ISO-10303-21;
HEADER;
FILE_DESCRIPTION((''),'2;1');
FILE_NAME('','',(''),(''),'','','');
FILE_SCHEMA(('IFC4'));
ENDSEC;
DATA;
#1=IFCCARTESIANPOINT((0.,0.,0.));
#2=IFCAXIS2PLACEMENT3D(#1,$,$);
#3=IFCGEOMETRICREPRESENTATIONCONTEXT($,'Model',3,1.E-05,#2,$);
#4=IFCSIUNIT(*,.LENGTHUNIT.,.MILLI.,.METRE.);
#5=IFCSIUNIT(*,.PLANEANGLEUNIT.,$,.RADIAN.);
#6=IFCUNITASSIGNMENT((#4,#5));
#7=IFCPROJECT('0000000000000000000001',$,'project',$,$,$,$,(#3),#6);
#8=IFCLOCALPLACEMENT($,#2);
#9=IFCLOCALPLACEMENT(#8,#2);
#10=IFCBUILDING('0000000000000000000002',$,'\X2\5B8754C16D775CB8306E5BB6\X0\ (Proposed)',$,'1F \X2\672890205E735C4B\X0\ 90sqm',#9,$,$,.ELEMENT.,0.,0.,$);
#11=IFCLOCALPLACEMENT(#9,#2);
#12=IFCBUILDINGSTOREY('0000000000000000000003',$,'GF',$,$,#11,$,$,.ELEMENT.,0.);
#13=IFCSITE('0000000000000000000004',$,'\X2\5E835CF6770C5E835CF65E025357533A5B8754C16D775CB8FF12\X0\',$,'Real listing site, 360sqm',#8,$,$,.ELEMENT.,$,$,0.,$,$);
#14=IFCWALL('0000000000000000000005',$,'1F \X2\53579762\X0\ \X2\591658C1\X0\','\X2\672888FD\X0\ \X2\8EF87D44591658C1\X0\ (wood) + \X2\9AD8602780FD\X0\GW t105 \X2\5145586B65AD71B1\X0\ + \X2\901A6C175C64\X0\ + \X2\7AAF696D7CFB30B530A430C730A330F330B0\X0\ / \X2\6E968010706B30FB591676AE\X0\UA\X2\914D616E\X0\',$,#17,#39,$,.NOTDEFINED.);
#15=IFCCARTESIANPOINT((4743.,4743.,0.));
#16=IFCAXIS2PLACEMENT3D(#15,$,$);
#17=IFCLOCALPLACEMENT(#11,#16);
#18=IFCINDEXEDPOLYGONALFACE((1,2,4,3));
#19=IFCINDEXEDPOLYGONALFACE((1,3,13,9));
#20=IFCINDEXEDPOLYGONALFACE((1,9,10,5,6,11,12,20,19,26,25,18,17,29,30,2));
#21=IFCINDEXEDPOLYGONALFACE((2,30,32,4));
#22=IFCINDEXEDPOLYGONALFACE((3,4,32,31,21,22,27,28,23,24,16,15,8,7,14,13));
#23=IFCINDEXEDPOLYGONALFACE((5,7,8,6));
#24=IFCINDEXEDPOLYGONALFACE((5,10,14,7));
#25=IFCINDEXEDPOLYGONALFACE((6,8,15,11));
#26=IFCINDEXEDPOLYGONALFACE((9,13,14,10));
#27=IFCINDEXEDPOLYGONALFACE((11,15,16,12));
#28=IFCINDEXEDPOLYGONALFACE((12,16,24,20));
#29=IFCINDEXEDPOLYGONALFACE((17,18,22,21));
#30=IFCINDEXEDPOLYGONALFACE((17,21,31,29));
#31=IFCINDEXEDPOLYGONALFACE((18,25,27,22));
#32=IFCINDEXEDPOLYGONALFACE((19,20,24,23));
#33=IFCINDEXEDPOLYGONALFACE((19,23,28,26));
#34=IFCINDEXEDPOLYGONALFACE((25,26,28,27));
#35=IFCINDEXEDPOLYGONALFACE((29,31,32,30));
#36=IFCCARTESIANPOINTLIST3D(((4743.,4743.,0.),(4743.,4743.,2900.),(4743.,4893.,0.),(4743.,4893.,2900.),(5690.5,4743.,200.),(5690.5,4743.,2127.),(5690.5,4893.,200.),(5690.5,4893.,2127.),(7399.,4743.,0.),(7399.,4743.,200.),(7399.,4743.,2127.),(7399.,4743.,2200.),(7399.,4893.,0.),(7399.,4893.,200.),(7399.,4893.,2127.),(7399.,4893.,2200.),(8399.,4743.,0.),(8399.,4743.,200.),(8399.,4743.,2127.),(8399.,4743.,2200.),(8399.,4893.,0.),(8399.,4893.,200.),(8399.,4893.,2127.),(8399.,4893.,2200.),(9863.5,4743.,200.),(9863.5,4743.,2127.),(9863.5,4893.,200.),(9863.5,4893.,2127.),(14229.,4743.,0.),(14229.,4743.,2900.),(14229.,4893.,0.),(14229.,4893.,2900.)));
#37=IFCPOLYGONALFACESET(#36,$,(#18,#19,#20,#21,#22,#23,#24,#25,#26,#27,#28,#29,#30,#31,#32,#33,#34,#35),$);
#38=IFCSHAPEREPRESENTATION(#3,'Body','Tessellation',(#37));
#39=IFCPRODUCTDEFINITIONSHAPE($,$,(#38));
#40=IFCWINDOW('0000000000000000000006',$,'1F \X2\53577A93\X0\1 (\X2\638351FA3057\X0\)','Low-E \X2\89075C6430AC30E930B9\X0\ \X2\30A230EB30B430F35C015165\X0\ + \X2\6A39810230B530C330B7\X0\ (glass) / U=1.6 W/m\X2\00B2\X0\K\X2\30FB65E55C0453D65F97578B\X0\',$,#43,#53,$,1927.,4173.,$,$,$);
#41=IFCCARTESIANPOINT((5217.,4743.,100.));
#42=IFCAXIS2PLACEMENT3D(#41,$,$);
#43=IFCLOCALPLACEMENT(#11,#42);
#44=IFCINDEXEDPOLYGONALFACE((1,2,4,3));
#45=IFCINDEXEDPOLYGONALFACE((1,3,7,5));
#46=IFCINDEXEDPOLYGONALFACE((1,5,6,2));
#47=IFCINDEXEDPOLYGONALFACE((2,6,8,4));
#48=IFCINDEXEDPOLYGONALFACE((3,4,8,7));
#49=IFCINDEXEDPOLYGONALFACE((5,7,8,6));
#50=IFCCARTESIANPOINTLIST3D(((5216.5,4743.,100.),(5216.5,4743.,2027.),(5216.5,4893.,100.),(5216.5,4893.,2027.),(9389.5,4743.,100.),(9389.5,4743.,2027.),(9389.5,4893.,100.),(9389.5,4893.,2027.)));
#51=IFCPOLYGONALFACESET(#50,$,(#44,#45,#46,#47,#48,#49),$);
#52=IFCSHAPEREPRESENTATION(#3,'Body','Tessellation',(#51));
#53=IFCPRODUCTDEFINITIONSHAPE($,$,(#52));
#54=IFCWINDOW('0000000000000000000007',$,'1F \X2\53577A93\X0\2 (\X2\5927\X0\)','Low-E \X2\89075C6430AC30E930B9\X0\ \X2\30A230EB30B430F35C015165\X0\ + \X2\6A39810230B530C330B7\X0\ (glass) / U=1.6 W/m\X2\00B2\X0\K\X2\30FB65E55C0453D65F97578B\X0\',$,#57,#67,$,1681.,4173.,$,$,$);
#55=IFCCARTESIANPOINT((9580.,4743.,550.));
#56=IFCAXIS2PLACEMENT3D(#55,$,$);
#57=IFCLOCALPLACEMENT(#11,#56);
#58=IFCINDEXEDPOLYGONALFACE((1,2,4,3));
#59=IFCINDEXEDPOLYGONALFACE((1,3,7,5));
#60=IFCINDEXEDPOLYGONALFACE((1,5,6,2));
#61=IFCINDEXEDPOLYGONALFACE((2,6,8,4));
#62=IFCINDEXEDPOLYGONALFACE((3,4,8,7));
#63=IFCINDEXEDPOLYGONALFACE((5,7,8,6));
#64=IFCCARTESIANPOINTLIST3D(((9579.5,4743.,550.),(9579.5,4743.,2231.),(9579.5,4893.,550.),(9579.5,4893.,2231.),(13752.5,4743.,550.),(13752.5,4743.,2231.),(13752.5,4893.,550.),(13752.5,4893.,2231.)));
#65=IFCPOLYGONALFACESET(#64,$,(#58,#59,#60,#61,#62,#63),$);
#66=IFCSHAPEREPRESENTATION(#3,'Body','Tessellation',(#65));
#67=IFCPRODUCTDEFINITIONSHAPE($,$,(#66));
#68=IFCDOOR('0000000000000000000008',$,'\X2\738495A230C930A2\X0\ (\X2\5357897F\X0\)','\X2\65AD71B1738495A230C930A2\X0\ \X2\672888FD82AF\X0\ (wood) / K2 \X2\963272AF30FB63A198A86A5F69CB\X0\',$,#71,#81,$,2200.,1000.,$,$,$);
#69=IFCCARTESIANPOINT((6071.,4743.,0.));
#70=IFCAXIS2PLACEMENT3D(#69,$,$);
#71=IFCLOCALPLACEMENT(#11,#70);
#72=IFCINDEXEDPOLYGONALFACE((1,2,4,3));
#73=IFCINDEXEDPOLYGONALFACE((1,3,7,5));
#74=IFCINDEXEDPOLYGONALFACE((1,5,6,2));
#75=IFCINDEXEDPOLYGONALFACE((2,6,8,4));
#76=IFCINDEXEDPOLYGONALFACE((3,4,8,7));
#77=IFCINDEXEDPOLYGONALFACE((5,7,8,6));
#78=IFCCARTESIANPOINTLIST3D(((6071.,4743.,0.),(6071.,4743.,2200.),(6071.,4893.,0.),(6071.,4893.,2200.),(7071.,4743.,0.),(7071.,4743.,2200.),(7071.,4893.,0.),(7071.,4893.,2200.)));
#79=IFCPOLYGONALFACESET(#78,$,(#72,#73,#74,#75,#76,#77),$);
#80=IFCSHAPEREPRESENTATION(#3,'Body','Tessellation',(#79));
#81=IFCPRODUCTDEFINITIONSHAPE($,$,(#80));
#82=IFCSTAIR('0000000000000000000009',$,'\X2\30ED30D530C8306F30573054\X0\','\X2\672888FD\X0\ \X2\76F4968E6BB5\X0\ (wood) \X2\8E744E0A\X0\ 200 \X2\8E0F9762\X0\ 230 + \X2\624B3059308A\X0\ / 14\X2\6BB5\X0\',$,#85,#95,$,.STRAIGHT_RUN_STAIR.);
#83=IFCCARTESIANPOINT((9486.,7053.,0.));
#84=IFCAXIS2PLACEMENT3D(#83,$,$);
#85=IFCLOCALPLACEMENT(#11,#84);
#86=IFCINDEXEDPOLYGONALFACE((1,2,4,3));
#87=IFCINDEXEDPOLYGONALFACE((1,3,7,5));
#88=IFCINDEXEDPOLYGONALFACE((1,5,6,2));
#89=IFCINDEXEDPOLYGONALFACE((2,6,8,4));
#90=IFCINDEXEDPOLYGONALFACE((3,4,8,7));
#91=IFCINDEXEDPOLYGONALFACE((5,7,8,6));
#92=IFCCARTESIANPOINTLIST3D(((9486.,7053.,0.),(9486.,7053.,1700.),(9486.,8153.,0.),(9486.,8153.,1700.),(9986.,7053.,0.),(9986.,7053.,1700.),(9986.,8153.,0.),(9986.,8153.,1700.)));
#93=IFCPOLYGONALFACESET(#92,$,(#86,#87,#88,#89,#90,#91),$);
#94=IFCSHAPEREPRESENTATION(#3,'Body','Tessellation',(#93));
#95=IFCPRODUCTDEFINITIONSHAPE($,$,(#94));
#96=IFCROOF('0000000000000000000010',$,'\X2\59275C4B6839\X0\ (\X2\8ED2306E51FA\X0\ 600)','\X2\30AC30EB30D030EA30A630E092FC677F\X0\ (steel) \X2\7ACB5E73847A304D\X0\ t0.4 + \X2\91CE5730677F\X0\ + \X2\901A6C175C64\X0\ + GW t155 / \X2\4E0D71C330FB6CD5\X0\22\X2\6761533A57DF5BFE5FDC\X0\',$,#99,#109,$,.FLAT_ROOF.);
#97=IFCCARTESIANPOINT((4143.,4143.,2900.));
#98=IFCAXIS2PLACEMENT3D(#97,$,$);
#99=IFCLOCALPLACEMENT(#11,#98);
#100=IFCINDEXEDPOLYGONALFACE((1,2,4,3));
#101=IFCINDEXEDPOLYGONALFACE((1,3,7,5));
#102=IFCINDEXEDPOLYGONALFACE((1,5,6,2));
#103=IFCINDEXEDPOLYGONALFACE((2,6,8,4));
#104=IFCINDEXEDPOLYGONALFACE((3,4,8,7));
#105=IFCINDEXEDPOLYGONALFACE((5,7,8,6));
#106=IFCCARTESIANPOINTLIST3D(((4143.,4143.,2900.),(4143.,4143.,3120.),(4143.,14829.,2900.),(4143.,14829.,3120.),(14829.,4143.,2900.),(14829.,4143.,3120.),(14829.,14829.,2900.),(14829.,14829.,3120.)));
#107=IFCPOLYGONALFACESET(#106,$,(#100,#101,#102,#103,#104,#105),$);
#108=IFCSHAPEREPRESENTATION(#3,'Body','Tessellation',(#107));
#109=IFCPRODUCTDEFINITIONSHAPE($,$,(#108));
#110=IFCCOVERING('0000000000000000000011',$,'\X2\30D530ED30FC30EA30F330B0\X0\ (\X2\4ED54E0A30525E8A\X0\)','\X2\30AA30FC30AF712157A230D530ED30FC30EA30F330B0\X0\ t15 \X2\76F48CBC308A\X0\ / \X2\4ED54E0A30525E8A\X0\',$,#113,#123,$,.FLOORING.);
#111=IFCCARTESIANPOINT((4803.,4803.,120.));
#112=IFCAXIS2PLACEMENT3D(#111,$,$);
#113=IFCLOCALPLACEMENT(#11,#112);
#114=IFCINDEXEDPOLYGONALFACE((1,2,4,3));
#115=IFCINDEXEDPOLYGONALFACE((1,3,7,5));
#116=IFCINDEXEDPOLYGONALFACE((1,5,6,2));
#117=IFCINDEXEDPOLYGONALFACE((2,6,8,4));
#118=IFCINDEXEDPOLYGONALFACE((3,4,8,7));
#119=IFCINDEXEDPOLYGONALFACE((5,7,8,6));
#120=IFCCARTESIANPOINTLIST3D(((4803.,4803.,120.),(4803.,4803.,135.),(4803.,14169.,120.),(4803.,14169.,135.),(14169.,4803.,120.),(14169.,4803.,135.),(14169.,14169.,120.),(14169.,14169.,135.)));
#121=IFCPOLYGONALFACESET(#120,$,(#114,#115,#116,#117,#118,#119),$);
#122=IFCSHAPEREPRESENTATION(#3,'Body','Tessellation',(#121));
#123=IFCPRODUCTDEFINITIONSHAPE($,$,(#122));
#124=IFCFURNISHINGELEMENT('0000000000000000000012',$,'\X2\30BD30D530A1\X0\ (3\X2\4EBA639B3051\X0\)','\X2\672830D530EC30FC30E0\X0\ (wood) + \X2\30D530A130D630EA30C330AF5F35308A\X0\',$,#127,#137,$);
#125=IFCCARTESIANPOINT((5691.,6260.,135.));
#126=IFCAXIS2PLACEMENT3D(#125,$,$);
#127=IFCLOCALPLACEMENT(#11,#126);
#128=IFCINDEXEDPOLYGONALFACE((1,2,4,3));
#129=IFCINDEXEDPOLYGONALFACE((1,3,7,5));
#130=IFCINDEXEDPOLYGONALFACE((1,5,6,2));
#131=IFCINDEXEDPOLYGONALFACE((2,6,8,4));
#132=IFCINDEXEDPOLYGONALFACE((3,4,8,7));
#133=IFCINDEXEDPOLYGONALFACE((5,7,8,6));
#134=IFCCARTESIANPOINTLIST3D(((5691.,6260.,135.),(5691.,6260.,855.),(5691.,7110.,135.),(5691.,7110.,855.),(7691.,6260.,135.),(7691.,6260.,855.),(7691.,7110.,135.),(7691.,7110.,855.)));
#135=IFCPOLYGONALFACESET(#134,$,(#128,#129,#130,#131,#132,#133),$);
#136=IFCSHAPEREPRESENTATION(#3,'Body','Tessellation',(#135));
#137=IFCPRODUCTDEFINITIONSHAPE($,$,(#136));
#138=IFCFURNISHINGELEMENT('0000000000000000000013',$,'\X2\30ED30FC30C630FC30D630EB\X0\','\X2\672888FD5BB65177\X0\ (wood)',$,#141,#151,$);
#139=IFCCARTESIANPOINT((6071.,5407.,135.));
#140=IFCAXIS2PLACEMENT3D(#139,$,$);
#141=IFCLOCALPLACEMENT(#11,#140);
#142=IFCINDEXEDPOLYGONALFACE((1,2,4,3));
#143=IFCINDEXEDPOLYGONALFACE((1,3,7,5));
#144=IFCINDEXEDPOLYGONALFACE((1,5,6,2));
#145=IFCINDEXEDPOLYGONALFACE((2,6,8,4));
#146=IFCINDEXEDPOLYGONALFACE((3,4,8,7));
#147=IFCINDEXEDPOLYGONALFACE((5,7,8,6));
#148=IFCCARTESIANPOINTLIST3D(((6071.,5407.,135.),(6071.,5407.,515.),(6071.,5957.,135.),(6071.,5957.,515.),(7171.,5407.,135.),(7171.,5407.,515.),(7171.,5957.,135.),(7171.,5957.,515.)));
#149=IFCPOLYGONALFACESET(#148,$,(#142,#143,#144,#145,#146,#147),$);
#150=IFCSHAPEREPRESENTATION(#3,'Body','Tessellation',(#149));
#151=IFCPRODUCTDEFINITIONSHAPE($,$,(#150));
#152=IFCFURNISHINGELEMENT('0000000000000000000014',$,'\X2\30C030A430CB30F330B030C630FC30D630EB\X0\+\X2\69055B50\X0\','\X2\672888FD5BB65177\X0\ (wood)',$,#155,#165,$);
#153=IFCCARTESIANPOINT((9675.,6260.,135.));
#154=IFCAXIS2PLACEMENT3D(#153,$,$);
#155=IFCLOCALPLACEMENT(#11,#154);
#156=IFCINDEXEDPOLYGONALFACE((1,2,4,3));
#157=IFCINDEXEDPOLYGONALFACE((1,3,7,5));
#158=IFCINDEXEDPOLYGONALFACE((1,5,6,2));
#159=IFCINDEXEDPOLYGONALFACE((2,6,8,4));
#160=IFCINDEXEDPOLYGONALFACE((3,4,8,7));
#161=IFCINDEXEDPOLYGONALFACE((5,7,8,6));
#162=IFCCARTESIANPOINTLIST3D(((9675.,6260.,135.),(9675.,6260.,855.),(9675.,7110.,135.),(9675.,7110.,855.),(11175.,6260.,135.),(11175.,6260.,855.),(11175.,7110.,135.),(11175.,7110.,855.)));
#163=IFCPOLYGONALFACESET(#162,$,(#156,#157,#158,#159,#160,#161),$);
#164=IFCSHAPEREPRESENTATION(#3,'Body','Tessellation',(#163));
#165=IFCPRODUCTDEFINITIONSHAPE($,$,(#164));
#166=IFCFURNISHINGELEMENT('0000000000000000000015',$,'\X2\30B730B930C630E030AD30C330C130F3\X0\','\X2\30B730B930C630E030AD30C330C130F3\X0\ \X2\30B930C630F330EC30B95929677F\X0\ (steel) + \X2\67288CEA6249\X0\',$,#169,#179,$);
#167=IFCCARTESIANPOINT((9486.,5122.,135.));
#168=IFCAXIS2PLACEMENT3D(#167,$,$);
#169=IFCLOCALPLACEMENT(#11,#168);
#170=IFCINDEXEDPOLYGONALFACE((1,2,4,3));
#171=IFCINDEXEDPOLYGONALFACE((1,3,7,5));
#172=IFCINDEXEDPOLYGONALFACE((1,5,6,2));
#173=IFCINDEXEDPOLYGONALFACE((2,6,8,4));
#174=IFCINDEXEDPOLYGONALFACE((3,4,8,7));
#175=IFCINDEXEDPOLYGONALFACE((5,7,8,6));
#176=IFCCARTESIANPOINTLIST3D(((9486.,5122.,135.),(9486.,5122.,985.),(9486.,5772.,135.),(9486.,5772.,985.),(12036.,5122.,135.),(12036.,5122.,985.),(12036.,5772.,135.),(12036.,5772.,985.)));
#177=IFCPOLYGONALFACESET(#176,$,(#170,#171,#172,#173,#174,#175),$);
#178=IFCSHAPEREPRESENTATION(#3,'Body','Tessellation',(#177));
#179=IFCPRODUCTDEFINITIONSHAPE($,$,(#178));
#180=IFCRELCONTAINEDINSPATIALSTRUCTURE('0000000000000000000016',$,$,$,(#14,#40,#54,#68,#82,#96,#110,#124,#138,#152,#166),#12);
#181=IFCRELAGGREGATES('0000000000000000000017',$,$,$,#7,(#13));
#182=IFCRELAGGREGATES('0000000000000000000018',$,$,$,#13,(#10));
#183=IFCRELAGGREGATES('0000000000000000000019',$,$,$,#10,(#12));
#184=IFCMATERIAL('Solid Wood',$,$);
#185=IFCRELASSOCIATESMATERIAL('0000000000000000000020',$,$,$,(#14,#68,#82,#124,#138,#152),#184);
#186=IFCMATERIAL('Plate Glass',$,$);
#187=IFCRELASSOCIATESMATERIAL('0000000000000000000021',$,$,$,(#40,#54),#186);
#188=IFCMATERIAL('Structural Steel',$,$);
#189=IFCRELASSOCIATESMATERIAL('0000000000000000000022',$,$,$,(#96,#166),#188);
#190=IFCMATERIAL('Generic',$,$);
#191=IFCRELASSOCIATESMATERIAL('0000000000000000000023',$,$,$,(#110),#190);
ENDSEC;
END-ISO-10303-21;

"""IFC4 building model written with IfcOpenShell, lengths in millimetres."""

from ifc_helpers import new_model, si_unit, frame, frame_2d, origin, place, context, project, spatial, rectangle, extrude, material, element, fill, save


model = new_model("IFC4")

# Units and contexts
model_context = context("Model", 3, precision=1e-05, world=origin())
ifc_project = project(units=[si_unit("LENGTHUNIT", "METRE", prefix="MILLI"), si_unit("PLANEANGLEUNIT", "RADIAN")], contexts=[model_context])

# Site, building, storey
site_placement = place(None, origin())
site = spatial("IfcSite", under=ifc_project, at=site_placement, Name="広島県広島市南区宇品海岸２", ObjectType="Real listing site, 360sqm", CompositionType="ELEMENT", RefElevation=0.0)
building_placement = place(site_placement, origin())
building = spatial("IfcBuilding", under=site, at=building_placement, Name="宇品海岸の家 (Proposed)", ObjectType="1F 木造平屋 90sqm", CompositionType="ELEMENT", ElevationOfRefHeight=0.0, ElevationOfTerrain=0.0)
storey_placement = place(building_placement, origin())
storey = spatial("IfcBuildingStorey", under=building, at=storey_placement, Name="GF", CompositionType="ELEMENT", Elevation=0.0)

# Shared definitions
ifc_material_1 = material(Name="Solid Wood")

# Wall, openings, windows, door
wall_1_placement = place(storey_placement, frame((4743.0, 4743.0, 0.0)))
wall_1 = element("IfcWall", 1, at=wall_1_placement, inside=storey, material=ifc_material_1, Name="1F 南面 外壁", Description="木製 軸組外壁 (wood) + 高性能GW t105 充填断熱 + 通気層 + 窯業系サイディング / 準耐火・外皮UA配慮", PredefinedType="NOTDEFINED", context=model_context, shape_type="SweptSolid", body=[
    extrude(rectangle(XDim=9486.0, YDim=150.0, at=frame_2d((4743.0, 75.0))), frame((4743.0, 4743.0, 0.0)), (0.0, 0.0, 1.0), 2900.0),
])
opening_1_placement = place(storey_placement, frame((5217.0, 4743.0, 100.0)))
opening_1 = element("IfcOpeningElement", 2, at=opening_1_placement, cuts=wall_1, PredefinedType="NOTDEFINED", context=model_context, shape_type="SweptSolid", body=[
    extrude(rectangle(XDim=4173.0, YDim=150.0, at=frame_2d((2086.0, 75.0))), frame((5217.0, 4743.0, 100.0)), (0.0, 0.0, 1.0), 1927.0),
])
opening_2_placement = place(storey_placement, frame((9580.0, 4743.0, 550.0)))
opening_2 = element("IfcOpeningElement", 3, at=opening_2_placement, cuts=wall_1, PredefinedType="NOTDEFINED", context=model_context, shape_type="SweptSolid", body=[
    extrude(rectangle(XDim=4173.0, YDim=150.0, at=frame_2d((2086.0, 75.0))), frame((9580.0, 4743.0, 550.0)), (0.0, 0.0, 1.0), 1681.0),
])
opening_3_placement = place(storey_placement, frame((6071.0, 4743.0, 0.0)))
opening_3 = element("IfcOpeningElement", 4, at=opening_3_placement, cuts=wall_1, PredefinedType="NOTDEFINED", context=model_context, shape_type="SweptSolid", body=[
    extrude(rectangle(XDim=1000.0, YDim=150.0, at=frame_2d((500.0, 75.0))), frame((6071.0, 4743.0, 0.0)), (0.0, 0.0, 1.0), 2200.0),
])
ifc_material_2 = material(Name="Plate Glass")
window_1_placement = place(storey_placement, frame((5217.0, 4743.0, 100.0)))
window_1 = element("IfcWindow", 5, at=window_1_placement, inside=storey, material=ifc_material_2, Name="1F 南窓1 (掃出し)", Description="Low-E 複層ガラス アルゴン封入 + 樹脂サッシ (glass) / U=1.6 W/m²K・日射取得型", OverallHeight=1927.0, OverallWidth=4173.0, context=model_context, shape_type="SweptSolid", body=[
    extrude(rectangle(XDim=4173.0, YDim=150.0, at=frame_2d((2086.0, 75.0))), frame((5217.0, 4743.0, 100.0)), (0.0, 0.0, 1.0), 1927.0),
])
fill(opening_1, window_1)
window_2_placement = place(storey_placement, frame((9580.0, 4743.0, 550.0)))
window_2 = element("IfcWindow", 6, at=window_2_placement, inside=storey, material=ifc_material_2, Name="1F 南窓2 (大)", Description="Low-E 複層ガラス アルゴン封入 + 樹脂サッシ (glass) / U=1.6 W/m²K・日射取得型", OverallHeight=1681.0, OverallWidth=4173.0, context=model_context, shape_type="SweptSolid", body=[
    extrude(rectangle(XDim=4173.0, YDim=150.0, at=frame_2d((2086.0, 75.0))), frame((9580.0, 4743.0, 550.0)), (0.0, 0.0, 1.0), 1681.0),
])
fill(opening_2, window_2)
door_placement = place(storey_placement, frame((6071.0, 4743.0, 0.0)))
door = element("IfcDoor", 7, at=door_placement, inside=storey, material=ifc_material_1, Name="玄関ドア (南西)", Description="断熱玄関ドア 木製芯 (wood) / K2 防犯・採風機構", OverallHeight=2200.0, OverallWidth=1000.0, context=model_context, shape_type="SweptSolid", body=[
    extrude(rectangle(XDim=1000.0, YDim=150.0, at=frame_2d((500.0, 75.0))), frame((6071.0, 4743.0, 0.0)), (0.0, 0.0, 1.0), 2200.0),
])
fill(opening_3, door)

# Stair
stair_placement = place(storey_placement, frame((9486.0, 7053.0, 0.0)))
element("IfcStair", 8, at=stair_placement, inside=storey, material=ifc_material_1, Name="ロフトはしご", Description="木製 直階段 (wood) 蹴上 200 踏面 230 + 手すり / 14段", PredefinedType="STRAIGHT_RUN_STAIR", context=model_context, shape_type="SweptSolid", body=[
    extrude(rectangle(XDim=500.0, YDim=1100.0, at=frame_2d((250.0, 550.0))), frame((9486.0, 7053.0, 0.0)), (0.0, 0.0, 1.0), 1700.0),
])

# Roof
ifc_material_3 = material(Name="Structural Steel")
roof_placement = place(storey_placement, frame((4143.0, 4143.0, 2900.0)))
element("IfcRoof", 9, at=roof_placement, inside=storey, material=ifc_material_3, Name="大屋根 (軒の出 600)", Description="ガルバリウム鋼板 (steel) 立平葺き t0.4 + 野地板 + 通気層 + GW t155 / 不燃・法22条区域対応", PredefinedType="FLAT_ROOF", context=model_context, shape_type="SweptSolid", body=[
    extrude(rectangle(XDim=10686.0, YDim=10686.0, at=frame_2d((5343.0, 5343.0))), frame((4143.0, 4143.0, 2900.0)), (0.0, 0.0, 1.0), 220.0),
])

# Covering
ifc_material_4 = material(Name="Generic")
covering_placement = place(storey_placement, frame((4803.0, 4803.0, 120.0)))
element("IfcCovering", 10, at=covering_placement, inside=storey, material=ifc_material_4, Name="フローリング (仕上げ床)", Description="オーク無垢フローリング t15 直貼り / 仕上げ床", PredefinedType="FLOORING", context=model_context, shape_type="SweptSolid", body=[
    extrude(rectangle(XDim=9366.0, YDim=9366.0, at=frame_2d((4683.0, 4683.0))), frame((4803.0, 4803.0, 120.0)), (0.0, 0.0, 1.0), 15.0),
])

# Furnishing elements
furnishing_1_placement = place(storey_placement, frame((5691.0, 6260.0, 135.0)))
element("IfcFurnishingElement", 11, at=furnishing_1_placement, inside=storey, material=ifc_material_1, Name="ソファ (3人掛け)", Description="木フレーム (wood) + ファブリック張り", context=model_context, shape_type="SweptSolid", body=[
    extrude(rectangle(XDim=2000.0, YDim=850.0, at=frame_2d((1000.0, 425.0))), frame((5691.0, 6260.0, 135.0)), (0.0, 0.0, 1.0), 720.0),
])
furnishing_2_placement = place(storey_placement, frame((6071.0, 5407.0, 135.0)))
element("IfcFurnishingElement", 12, at=furnishing_2_placement, inside=storey, material=ifc_material_1, Name="ローテーブル", Description="木製家具 (wood)", context=model_context, shape_type="SweptSolid", body=[
    extrude(rectangle(XDim=1100.0, YDim=550.0, at=frame_2d((550.0, 275.0))), frame((6071.0, 5407.0, 135.0)), (0.0, 0.0, 1.0), 380.0),
])
furnishing_3_placement = place(storey_placement, frame((9675.0, 6260.0, 135.0)))
element("IfcFurnishingElement", 13, at=furnishing_3_placement, inside=storey, material=ifc_material_1, Name="ダイニングテーブル+椅子", Description="木製家具 (wood)", context=model_context, shape_type="SweptSolid", body=[
    extrude(rectangle(XDim=1500.0, YDim=850.0, at=frame_2d((750.0, 425.0))), frame((9675.0, 6260.0, 135.0)), (0.0, 0.0, 1.0), 720.0),
])
furnishing_4_placement = place(storey_placement, frame((9486.0, 5122.0, 135.0)))
element("IfcFurnishingElement", 14, at=furnishing_4_placement, inside=storey, material=ifc_material_3, Name="システムキッチン", Description="システムキッチン ステンレス天板 (steel) + 木質扉", context=model_context, shape_type="SweptSolid", body=[
    extrude(rectangle(XDim=2550.0, YDim=650.0, at=frame_2d((1275.0, 325.0))), frame((9486.0, 5122.0, 135.0)), (0.0, 0.0, 1.0), 850.0),
])

save(model, "model.ifc")
